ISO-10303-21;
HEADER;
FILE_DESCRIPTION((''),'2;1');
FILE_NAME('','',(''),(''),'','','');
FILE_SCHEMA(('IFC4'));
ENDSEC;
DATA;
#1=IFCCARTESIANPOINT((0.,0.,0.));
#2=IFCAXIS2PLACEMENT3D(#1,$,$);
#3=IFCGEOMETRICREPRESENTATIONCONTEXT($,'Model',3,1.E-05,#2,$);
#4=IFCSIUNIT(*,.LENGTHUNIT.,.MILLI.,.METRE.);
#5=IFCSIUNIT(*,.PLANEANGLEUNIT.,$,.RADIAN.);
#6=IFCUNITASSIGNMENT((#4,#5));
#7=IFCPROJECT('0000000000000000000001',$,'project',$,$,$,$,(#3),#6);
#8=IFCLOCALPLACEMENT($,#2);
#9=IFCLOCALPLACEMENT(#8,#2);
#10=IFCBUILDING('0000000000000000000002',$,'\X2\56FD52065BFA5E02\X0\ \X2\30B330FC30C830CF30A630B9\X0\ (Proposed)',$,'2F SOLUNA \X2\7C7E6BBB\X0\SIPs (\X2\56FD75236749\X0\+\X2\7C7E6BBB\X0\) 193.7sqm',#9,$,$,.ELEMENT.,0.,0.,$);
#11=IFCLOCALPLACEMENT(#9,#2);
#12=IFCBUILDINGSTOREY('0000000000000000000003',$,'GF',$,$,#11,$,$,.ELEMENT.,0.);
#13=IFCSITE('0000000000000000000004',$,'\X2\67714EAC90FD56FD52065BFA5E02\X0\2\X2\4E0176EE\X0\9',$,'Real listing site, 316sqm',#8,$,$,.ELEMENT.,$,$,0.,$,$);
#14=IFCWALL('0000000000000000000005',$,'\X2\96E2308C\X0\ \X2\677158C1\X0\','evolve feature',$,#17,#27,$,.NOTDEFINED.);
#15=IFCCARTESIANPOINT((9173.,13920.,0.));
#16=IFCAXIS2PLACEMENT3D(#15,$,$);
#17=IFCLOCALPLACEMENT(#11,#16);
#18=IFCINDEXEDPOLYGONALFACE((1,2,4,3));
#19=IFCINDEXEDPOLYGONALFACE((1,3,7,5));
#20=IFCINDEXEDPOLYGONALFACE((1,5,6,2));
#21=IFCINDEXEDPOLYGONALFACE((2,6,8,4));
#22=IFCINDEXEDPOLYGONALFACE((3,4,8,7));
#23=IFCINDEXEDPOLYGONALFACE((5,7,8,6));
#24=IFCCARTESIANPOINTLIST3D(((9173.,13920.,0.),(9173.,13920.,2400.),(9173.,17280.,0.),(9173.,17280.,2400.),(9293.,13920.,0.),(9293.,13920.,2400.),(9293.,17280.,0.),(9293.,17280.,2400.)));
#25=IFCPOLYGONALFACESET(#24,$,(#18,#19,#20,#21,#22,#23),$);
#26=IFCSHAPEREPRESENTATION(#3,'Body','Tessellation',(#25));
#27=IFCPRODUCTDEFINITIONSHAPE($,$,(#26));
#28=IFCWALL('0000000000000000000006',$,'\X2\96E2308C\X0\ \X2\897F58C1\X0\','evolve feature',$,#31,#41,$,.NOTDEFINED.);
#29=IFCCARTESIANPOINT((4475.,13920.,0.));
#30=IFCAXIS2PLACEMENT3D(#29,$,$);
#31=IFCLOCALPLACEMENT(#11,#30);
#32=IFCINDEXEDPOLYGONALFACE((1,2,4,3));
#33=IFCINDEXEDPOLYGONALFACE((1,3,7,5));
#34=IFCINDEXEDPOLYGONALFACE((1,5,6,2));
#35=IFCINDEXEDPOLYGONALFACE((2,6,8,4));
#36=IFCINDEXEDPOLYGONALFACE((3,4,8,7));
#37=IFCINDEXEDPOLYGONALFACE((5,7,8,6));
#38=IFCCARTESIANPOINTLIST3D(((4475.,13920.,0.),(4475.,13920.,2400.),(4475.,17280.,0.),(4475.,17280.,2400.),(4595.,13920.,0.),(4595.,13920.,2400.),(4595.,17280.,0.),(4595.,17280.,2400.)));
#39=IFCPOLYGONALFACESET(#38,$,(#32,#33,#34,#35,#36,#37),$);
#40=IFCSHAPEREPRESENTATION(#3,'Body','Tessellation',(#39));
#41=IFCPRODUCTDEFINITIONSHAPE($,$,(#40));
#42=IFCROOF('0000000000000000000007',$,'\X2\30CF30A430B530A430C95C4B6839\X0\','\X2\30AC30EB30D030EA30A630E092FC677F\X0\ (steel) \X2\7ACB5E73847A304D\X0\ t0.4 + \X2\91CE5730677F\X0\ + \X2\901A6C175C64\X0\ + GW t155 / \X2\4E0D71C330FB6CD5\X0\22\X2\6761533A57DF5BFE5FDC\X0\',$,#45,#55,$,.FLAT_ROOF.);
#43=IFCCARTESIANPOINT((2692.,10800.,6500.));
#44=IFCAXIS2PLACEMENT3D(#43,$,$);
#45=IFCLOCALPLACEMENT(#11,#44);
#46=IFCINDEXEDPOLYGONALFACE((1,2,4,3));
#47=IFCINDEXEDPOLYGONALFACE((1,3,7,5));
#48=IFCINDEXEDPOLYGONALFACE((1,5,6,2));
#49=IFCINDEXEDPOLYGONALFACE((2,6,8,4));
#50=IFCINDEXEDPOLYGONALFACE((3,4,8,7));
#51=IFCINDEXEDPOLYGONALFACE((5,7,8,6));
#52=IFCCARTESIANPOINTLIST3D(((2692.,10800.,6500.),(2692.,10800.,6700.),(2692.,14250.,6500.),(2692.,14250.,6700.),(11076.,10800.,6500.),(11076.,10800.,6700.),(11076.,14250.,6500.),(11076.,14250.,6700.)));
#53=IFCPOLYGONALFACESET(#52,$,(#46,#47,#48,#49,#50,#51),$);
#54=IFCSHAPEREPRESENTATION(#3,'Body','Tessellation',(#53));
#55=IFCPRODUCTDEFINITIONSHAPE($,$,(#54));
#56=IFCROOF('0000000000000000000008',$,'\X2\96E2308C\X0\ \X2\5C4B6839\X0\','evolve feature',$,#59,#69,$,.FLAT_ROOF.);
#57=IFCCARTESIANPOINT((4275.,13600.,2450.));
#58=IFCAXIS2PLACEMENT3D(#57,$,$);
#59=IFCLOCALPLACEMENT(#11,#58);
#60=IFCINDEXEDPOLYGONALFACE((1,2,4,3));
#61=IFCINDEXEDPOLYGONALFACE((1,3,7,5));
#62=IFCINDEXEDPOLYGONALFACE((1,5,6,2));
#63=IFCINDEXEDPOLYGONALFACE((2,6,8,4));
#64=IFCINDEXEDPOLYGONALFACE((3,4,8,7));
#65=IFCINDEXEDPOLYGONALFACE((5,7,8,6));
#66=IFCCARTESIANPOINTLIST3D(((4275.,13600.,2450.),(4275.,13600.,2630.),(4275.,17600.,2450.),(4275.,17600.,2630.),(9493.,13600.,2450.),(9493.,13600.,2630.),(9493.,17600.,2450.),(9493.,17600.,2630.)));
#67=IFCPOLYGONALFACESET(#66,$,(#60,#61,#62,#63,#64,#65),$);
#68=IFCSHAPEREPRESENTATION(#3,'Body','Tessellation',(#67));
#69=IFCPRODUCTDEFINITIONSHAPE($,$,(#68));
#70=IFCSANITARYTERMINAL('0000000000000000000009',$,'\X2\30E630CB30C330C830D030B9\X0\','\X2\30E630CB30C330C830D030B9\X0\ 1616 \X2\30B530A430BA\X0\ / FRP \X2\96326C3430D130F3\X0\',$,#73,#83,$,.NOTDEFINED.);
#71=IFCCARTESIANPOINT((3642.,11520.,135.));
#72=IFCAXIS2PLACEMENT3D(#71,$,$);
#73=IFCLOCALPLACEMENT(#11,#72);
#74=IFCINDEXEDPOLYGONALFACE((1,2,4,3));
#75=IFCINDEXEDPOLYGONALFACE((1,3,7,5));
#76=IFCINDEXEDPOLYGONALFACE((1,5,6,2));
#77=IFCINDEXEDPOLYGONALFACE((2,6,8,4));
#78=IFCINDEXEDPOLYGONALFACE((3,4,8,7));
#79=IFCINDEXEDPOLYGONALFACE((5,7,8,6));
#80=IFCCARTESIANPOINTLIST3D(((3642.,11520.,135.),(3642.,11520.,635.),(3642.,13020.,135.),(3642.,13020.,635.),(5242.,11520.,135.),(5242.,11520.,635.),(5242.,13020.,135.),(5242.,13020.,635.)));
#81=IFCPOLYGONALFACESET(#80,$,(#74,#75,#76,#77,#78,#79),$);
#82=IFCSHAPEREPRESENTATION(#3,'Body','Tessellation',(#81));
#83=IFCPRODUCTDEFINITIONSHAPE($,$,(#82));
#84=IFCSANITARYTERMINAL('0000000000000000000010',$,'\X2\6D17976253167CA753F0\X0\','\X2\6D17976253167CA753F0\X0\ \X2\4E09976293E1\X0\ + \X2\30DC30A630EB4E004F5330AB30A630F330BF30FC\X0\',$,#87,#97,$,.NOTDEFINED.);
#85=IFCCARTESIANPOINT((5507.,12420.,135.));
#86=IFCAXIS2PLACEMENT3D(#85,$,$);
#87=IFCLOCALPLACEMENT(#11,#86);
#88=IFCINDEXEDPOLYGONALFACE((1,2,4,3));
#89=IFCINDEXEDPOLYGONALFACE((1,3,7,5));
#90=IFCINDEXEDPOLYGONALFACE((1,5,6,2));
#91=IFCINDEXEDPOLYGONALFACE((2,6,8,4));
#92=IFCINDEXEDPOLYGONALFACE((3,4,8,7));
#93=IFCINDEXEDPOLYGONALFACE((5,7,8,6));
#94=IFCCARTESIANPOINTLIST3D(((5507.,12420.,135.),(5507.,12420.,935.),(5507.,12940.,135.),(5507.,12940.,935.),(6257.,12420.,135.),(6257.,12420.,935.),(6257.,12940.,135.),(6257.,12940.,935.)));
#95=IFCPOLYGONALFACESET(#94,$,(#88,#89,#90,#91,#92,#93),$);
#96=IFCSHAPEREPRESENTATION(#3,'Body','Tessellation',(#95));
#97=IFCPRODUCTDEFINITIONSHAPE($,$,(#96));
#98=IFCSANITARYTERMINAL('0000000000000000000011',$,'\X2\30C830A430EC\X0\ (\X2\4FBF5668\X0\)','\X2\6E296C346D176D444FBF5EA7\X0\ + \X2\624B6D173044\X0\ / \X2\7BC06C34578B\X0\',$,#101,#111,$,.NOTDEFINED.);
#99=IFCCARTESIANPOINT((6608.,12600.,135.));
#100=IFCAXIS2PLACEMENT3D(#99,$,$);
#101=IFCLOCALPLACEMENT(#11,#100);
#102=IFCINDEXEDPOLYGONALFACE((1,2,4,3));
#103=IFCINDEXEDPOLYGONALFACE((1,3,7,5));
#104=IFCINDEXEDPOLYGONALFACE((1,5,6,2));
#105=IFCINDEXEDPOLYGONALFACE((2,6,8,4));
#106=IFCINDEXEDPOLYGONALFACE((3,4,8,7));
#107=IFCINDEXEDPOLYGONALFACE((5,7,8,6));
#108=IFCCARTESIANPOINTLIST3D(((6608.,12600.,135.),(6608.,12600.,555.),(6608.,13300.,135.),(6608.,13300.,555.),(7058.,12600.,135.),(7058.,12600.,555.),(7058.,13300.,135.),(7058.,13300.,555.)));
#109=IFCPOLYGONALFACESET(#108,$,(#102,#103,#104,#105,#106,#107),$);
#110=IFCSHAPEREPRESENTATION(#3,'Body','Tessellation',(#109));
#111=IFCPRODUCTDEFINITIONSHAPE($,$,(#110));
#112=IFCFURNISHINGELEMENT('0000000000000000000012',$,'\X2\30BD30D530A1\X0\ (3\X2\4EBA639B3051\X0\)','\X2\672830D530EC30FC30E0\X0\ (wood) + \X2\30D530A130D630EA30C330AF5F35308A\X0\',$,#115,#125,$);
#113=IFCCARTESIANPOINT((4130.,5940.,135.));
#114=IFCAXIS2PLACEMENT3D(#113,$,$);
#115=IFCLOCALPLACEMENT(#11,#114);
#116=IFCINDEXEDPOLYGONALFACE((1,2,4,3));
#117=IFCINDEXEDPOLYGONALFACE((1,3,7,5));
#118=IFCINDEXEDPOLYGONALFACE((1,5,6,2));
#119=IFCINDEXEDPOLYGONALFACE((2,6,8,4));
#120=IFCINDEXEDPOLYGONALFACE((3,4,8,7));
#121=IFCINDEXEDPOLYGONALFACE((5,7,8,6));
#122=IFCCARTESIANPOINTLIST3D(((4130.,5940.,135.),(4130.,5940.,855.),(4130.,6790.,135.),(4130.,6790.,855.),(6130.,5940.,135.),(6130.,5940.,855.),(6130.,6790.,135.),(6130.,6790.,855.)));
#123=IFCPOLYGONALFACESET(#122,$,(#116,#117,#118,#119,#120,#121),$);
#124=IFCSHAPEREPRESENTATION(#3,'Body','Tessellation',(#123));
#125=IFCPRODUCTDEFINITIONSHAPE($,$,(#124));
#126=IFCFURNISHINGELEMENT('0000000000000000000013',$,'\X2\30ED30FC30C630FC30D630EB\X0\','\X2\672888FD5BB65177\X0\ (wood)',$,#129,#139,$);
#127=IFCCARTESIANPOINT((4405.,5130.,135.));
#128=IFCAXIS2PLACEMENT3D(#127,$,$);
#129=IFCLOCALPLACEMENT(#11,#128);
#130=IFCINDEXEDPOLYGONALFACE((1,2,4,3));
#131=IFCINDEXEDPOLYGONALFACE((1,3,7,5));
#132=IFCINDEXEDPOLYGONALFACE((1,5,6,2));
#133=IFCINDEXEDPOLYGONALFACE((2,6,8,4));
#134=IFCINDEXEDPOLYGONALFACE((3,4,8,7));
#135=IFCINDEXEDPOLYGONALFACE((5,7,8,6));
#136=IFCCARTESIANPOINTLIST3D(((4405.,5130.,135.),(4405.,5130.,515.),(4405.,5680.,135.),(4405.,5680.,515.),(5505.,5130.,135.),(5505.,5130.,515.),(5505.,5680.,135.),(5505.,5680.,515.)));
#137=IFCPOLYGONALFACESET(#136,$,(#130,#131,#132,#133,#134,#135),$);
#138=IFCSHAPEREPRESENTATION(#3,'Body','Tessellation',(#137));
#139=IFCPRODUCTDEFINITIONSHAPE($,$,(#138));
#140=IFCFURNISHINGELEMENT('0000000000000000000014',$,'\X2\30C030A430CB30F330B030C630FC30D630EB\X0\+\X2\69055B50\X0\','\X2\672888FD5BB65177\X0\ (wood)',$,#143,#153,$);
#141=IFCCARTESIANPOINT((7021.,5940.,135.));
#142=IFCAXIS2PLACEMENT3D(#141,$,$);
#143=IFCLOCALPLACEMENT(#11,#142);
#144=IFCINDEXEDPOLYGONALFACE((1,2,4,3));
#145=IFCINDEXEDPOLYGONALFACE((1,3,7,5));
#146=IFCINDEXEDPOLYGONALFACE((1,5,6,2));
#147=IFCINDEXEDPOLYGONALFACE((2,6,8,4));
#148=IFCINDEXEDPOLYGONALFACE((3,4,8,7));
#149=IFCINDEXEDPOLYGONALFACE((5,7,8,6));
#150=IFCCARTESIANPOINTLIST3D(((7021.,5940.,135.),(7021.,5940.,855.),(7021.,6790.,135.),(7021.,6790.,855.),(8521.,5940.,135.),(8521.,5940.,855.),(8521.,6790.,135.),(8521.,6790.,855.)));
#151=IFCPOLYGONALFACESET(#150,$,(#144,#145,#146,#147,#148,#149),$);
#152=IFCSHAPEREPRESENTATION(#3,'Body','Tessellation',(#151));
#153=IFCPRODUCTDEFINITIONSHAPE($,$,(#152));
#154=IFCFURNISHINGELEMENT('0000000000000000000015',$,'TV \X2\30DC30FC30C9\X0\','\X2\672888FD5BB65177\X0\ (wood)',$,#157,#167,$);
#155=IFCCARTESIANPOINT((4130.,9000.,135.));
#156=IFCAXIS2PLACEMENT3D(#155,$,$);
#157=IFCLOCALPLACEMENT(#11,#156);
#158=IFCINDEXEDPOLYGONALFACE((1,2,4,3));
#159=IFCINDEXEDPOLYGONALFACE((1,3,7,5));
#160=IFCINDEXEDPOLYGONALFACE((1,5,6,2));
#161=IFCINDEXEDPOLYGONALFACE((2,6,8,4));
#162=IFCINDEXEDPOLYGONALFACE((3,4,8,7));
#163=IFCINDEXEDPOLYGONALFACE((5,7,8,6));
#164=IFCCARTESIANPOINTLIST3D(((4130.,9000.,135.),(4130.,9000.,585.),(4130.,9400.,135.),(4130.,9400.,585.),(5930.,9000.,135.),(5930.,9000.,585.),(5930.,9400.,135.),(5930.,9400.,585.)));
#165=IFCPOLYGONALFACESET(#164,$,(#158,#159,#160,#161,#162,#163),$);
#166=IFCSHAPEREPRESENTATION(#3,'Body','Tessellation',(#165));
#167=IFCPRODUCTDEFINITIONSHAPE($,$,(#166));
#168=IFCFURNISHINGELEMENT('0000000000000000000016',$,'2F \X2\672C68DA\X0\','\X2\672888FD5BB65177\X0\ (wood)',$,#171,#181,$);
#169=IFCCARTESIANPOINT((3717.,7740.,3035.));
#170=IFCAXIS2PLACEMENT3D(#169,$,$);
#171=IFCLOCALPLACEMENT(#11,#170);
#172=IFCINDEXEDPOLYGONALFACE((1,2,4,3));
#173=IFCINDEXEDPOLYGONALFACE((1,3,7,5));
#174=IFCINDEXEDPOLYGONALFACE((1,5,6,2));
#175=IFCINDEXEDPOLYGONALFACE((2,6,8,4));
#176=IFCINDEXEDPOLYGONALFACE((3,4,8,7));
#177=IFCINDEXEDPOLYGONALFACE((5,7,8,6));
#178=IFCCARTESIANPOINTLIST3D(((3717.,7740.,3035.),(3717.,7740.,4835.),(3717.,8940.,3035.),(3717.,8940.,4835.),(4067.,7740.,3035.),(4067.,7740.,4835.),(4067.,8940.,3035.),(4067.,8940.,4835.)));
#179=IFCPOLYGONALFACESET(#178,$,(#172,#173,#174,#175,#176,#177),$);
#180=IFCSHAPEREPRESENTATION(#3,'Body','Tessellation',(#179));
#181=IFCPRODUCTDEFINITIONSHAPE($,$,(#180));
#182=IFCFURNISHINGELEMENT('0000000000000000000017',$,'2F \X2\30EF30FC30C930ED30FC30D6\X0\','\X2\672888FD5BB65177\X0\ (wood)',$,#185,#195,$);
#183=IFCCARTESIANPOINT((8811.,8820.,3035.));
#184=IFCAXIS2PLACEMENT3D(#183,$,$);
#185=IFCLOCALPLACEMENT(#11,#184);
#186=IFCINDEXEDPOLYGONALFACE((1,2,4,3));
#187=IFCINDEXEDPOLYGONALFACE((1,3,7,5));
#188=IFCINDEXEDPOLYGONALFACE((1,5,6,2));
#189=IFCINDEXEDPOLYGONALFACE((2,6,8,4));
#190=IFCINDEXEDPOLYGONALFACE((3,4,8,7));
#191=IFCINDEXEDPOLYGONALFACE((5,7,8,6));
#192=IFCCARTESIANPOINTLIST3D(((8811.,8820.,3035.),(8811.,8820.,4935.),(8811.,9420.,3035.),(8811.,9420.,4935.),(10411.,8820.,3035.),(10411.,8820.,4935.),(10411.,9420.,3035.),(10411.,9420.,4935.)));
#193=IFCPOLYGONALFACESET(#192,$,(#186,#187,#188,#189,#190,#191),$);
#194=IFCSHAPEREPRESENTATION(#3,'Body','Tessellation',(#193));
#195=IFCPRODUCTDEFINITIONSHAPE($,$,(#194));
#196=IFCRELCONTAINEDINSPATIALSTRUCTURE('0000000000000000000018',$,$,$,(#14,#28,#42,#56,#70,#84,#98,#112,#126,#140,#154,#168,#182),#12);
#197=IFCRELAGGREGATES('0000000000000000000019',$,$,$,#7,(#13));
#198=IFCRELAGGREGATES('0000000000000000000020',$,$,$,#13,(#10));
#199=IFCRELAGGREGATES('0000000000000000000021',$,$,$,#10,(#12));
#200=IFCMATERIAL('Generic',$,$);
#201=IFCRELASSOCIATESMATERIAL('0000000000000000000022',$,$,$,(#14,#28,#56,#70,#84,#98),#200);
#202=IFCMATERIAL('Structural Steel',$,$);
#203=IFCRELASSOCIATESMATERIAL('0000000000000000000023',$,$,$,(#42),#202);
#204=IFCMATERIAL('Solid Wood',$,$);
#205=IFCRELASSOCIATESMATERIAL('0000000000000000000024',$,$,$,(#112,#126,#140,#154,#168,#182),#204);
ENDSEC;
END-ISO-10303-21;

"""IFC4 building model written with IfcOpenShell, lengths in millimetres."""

from ifc_helpers import new_model, si_unit, frame, frame_2d, origin, place, context, project, spatial, rectangle, extrude, material, element, save


model = new_model("IFC4")

# Units and contexts
model_context = context("Model", 3, precision=1e-05, world=origin())
ifc_project = project(units=[si_unit("LENGTHUNIT", "METRE", prefix="MILLI"), si_unit("PLANEANGLEUNIT", "RADIAN")], contexts=[model_context])

# Site, building, storey
site_placement = place(None, origin())
site = spatial("IfcSite", under=ifc_project, at=site_placement, Name="東京都国分寺市2丁目9", ObjectType="Real listing site, 316sqm", CompositionType="ELEMENT", RefElevation=0.0)
building_placement = place(site_placement, origin())
building = spatial("IfcBuilding", under=site, at=building_placement, Name="国分寺市 コートハウス (Proposed)", ObjectType="2F SOLUNA 籾殻SIPs (国産杉+籾殻) 193.7sqm", CompositionType="ELEMENT", ElevationOfRefHeight=0.0, ElevationOfTerrain=0.0)
storey_placement = place(building_placement, origin())
storey = spatial("IfcBuildingStorey", under=building, at=storey_placement, Name="GF", CompositionType="ELEMENT", Elevation=0.0)

# Shared definitions
ifc_material_1 = material(Name="Generic")

# Shared definitions
ifc_material_2 = material(Name="Solid Wood")

# Walls
wall_1_placement = place(storey_placement, frame((9173.0, 13920.0, 0.0)))
element("IfcWall", 1, at=wall_1_placement, inside=storey, material=ifc_material_1, Name="離れ 東壁", Description="evolve feature", PredefinedType="NOTDEFINED", context=model_context, shape_type="SweptSolid", body=[
    extrude(rectangle(XDim=120.0, YDim=3360.0, at=frame_2d((60.0, 1680.0))), frame((9173.0, 13920.0, 0.0)), (0.0, 0.0, 1.0), 2400.0),
])
wall_2_placement = place(storey_placement, frame((4475.0, 13920.0, 0.0)))
element("IfcWall", 2, at=wall_2_placement, inside=storey, material=ifc_material_1, Name="離れ 西壁", Description="evolve feature", PredefinedType="NOTDEFINED", context=model_context, shape_type="SweptSolid", body=[
    extrude(rectangle(XDim=120.0, YDim=3360.0, at=frame_2d((60.0, 1680.0))), frame((4475.0, 13920.0, 0.0)), (0.0, 0.0, 1.0), 2400.0),
])

# Roofs
ifc_material_3 = material(Name="Structural Steel")
roof_1_placement = place(storey_placement, frame((2692.0, 10800.0, 6500.0)))
element("IfcRoof", 3, at=roof_1_placement, inside=storey, material=ifc_material_3, Name="ハイサイド屋根", Description="ガルバリウム鋼板 (steel) 立平葺き t0.4 + 野地板 + 通気層 + GW t155 / 不燃・法22条区域対応", PredefinedType="FLAT_ROOF", context=model_context, shape_type="SweptSolid", body=[
    extrude(rectangle(XDim=8384.0, YDim=3450.0, at=frame_2d((4192.0, 1725.0))), frame((2692.0, 10800.0, 6500.0)), (0.0, 0.0, 1.0), 200.0),
])
roof_2_placement = place(storey_placement, frame((4275.0, 13600.0, 2450.0)))
element("IfcRoof", 4, at=roof_2_placement, inside=storey, material=ifc_material_1, Name="離れ 屋根", Description="evolve feature", PredefinedType="FLAT_ROOF", context=model_context, shape_type="SweptSolid", body=[
    extrude(rectangle(XDim=5218.0, YDim=4000.0, at=frame_2d((2609.0, 2000.0))), frame((4275.0, 13600.0, 2450.0)), (0.0, 0.0, 1.0), 180.0),
])

# Sanitary terminals
sanitary_terminal_1_placement = place(storey_placement, frame((3642.0, 11520.0, 135.0)))
element("IfcSanitaryTerminal", 5, at=sanitary_terminal_1_placement, inside=storey, material=ifc_material_1, Name="ユニットバス", Description="ユニットバス 1616 サイズ / FRP 防水パン", PredefinedType="NOTDEFINED", context=model_context, shape_type="SweptSolid", body=[
    extrude(rectangle(XDim=1600.0, YDim=1500.0, at=frame_2d((800.0, 750.0))), frame((3642.0, 11520.0, 135.0)), (0.0, 0.0, 1.0), 500.0),
])
sanitary_terminal_2_placement = place(storey_placement, frame((5507.0, 12420.0, 135.0)))
element("IfcSanitaryTerminal", 6, at=sanitary_terminal_2_placement, inside=storey, material=ifc_material_1, Name="洗面化粧台", Description="洗面化粧台 三面鏡 + ボウル一体カウンター", PredefinedType="NOTDEFINED", context=model_context, shape_type="SweptSolid", body=[
    extrude(rectangle(XDim=750.0, YDim=520.0, at=frame_2d((375.0, 260.0))), frame((5507.0, 12420.0, 135.0)), (0.0, 0.0, 1.0), 800.0),
])
sanitary_terminal_3_placement = place(storey_placement, frame((6608.0, 12600.0, 135.0)))
element("IfcSanitaryTerminal", 7, at=sanitary_terminal_3_placement, inside=storey, material=ifc_material_1, Name="トイレ (便器)", Description="温水洗浄便座 + 手洗い / 節水型", PredefinedType="NOTDEFINED", context=model_context, shape_type="SweptSolid", body=[
    extrude(rectangle(XDim=450.0, YDim=700.0, at=frame_2d((225.0, 350.0))), frame((6608.0, 12600.0, 135.0)), (0.0, 0.0, 1.0), 420.0),
])

# Furnishing elements
furnishing_1_placement = place(storey_placement, frame((4130.0, 5940.0, 135.0)))
element("IfcFurnishingElement", 8, at=furnishing_1_placement, inside=storey, material=ifc_material_2, Name="ソファ (3人掛け)", Description="木フレーム (wood) + ファブリック張り", context=model_context, shape_type="SweptSolid", body=[
    extrude(rectangle(XDim=2000.0, YDim=850.0, at=frame_2d((1000.0, 425.0))), frame((4130.0, 5940.0, 135.0)), (0.0, 0.0, 1.0), 720.0),
])
furnishing_2_placement = place(storey_placement, frame((4405.0, 5130.0, 135.0)))
element("IfcFurnishingElement", 9, at=furnishing_2_placement, inside=storey, material=ifc_material_2, Name="ローテーブル", Description="木製家具 (wood)", context=model_context, shape_type="SweptSolid", body=[
    extrude(rectangle(XDim=1100.0, YDim=550.0, at=frame_2d((550.0, 275.0))), frame((4405.0, 5130.0, 135.0)), (0.0, 0.0, 1.0), 380.0),
])
furnishing_3_placement = place(storey_placement, frame((7021.0, 5940.0, 135.0)))
element("IfcFurnishingElement", 10, at=furnishing_3_placement, inside=storey, material=ifc_material_2, Name="ダイニングテーブル+椅子", Description="木製家具 (wood)", context=model_context, shape_type="SweptSolid", body=[
    extrude(rectangle(XDim=1500.0, YDim=850.0, at=frame_2d((750.0, 425.0))), frame((7021.0, 5940.0, 135.0)), (0.0, 0.0, 1.0), 720.0),
])
furnishing_4_placement = place(storey_placement, frame((4130.0, 9000.0, 135.0)))
element("IfcFurnishingElement", 11, at=furnishing_4_placement, inside=storey, material=ifc_material_2, Name="TV ボード", Description="木製家具 (wood)", context=model_context, shape_type="SweptSolid", body=[
    extrude(rectangle(XDim=1800.0, YDim=400.0, at=frame_2d((900.0, 200.0))), frame((4130.0, 9000.0, 135.0)), (0.0, 0.0, 1.0), 450.0),
])
furnishing_5_placement = place(storey_placement, frame((3717.0, 7740.0, 3035.0)))
element("IfcFurnishingElement", 12, at=furnishing_5_placement, inside=storey, material=ifc_material_2, Name="2F 本棚", Description="木製家具 (wood)", context=model_context, shape_type="SweptSolid", body=[
    extrude(rectangle(XDim=350.0, YDim=1200.0, at=frame_2d((175.0, 600.0))), frame((3717.0, 7740.0, 3035.0)), (0.0, 0.0, 1.0), 1800.0),
])
furnishing_6_placement = place(storey_placement, frame((8811.0, 8820.0, 3035.0)))
element("IfcFurnishingElement", 13, at=furnishing_6_placement, inside=storey, material=ifc_material_2, Name="2F ワードローブ", Description="木製家具 (wood)", context=model_context, shape_type="SweptSolid", body=[
    extrude(rectangle(XDim=1600.0, YDim=600.0, at=frame_2d((800.0, 300.0))), frame((8811.0, 8820.0, 3035.0)), (0.0, 0.0, 1.0), 1900.0),
])

save(model, "model.ifc")
